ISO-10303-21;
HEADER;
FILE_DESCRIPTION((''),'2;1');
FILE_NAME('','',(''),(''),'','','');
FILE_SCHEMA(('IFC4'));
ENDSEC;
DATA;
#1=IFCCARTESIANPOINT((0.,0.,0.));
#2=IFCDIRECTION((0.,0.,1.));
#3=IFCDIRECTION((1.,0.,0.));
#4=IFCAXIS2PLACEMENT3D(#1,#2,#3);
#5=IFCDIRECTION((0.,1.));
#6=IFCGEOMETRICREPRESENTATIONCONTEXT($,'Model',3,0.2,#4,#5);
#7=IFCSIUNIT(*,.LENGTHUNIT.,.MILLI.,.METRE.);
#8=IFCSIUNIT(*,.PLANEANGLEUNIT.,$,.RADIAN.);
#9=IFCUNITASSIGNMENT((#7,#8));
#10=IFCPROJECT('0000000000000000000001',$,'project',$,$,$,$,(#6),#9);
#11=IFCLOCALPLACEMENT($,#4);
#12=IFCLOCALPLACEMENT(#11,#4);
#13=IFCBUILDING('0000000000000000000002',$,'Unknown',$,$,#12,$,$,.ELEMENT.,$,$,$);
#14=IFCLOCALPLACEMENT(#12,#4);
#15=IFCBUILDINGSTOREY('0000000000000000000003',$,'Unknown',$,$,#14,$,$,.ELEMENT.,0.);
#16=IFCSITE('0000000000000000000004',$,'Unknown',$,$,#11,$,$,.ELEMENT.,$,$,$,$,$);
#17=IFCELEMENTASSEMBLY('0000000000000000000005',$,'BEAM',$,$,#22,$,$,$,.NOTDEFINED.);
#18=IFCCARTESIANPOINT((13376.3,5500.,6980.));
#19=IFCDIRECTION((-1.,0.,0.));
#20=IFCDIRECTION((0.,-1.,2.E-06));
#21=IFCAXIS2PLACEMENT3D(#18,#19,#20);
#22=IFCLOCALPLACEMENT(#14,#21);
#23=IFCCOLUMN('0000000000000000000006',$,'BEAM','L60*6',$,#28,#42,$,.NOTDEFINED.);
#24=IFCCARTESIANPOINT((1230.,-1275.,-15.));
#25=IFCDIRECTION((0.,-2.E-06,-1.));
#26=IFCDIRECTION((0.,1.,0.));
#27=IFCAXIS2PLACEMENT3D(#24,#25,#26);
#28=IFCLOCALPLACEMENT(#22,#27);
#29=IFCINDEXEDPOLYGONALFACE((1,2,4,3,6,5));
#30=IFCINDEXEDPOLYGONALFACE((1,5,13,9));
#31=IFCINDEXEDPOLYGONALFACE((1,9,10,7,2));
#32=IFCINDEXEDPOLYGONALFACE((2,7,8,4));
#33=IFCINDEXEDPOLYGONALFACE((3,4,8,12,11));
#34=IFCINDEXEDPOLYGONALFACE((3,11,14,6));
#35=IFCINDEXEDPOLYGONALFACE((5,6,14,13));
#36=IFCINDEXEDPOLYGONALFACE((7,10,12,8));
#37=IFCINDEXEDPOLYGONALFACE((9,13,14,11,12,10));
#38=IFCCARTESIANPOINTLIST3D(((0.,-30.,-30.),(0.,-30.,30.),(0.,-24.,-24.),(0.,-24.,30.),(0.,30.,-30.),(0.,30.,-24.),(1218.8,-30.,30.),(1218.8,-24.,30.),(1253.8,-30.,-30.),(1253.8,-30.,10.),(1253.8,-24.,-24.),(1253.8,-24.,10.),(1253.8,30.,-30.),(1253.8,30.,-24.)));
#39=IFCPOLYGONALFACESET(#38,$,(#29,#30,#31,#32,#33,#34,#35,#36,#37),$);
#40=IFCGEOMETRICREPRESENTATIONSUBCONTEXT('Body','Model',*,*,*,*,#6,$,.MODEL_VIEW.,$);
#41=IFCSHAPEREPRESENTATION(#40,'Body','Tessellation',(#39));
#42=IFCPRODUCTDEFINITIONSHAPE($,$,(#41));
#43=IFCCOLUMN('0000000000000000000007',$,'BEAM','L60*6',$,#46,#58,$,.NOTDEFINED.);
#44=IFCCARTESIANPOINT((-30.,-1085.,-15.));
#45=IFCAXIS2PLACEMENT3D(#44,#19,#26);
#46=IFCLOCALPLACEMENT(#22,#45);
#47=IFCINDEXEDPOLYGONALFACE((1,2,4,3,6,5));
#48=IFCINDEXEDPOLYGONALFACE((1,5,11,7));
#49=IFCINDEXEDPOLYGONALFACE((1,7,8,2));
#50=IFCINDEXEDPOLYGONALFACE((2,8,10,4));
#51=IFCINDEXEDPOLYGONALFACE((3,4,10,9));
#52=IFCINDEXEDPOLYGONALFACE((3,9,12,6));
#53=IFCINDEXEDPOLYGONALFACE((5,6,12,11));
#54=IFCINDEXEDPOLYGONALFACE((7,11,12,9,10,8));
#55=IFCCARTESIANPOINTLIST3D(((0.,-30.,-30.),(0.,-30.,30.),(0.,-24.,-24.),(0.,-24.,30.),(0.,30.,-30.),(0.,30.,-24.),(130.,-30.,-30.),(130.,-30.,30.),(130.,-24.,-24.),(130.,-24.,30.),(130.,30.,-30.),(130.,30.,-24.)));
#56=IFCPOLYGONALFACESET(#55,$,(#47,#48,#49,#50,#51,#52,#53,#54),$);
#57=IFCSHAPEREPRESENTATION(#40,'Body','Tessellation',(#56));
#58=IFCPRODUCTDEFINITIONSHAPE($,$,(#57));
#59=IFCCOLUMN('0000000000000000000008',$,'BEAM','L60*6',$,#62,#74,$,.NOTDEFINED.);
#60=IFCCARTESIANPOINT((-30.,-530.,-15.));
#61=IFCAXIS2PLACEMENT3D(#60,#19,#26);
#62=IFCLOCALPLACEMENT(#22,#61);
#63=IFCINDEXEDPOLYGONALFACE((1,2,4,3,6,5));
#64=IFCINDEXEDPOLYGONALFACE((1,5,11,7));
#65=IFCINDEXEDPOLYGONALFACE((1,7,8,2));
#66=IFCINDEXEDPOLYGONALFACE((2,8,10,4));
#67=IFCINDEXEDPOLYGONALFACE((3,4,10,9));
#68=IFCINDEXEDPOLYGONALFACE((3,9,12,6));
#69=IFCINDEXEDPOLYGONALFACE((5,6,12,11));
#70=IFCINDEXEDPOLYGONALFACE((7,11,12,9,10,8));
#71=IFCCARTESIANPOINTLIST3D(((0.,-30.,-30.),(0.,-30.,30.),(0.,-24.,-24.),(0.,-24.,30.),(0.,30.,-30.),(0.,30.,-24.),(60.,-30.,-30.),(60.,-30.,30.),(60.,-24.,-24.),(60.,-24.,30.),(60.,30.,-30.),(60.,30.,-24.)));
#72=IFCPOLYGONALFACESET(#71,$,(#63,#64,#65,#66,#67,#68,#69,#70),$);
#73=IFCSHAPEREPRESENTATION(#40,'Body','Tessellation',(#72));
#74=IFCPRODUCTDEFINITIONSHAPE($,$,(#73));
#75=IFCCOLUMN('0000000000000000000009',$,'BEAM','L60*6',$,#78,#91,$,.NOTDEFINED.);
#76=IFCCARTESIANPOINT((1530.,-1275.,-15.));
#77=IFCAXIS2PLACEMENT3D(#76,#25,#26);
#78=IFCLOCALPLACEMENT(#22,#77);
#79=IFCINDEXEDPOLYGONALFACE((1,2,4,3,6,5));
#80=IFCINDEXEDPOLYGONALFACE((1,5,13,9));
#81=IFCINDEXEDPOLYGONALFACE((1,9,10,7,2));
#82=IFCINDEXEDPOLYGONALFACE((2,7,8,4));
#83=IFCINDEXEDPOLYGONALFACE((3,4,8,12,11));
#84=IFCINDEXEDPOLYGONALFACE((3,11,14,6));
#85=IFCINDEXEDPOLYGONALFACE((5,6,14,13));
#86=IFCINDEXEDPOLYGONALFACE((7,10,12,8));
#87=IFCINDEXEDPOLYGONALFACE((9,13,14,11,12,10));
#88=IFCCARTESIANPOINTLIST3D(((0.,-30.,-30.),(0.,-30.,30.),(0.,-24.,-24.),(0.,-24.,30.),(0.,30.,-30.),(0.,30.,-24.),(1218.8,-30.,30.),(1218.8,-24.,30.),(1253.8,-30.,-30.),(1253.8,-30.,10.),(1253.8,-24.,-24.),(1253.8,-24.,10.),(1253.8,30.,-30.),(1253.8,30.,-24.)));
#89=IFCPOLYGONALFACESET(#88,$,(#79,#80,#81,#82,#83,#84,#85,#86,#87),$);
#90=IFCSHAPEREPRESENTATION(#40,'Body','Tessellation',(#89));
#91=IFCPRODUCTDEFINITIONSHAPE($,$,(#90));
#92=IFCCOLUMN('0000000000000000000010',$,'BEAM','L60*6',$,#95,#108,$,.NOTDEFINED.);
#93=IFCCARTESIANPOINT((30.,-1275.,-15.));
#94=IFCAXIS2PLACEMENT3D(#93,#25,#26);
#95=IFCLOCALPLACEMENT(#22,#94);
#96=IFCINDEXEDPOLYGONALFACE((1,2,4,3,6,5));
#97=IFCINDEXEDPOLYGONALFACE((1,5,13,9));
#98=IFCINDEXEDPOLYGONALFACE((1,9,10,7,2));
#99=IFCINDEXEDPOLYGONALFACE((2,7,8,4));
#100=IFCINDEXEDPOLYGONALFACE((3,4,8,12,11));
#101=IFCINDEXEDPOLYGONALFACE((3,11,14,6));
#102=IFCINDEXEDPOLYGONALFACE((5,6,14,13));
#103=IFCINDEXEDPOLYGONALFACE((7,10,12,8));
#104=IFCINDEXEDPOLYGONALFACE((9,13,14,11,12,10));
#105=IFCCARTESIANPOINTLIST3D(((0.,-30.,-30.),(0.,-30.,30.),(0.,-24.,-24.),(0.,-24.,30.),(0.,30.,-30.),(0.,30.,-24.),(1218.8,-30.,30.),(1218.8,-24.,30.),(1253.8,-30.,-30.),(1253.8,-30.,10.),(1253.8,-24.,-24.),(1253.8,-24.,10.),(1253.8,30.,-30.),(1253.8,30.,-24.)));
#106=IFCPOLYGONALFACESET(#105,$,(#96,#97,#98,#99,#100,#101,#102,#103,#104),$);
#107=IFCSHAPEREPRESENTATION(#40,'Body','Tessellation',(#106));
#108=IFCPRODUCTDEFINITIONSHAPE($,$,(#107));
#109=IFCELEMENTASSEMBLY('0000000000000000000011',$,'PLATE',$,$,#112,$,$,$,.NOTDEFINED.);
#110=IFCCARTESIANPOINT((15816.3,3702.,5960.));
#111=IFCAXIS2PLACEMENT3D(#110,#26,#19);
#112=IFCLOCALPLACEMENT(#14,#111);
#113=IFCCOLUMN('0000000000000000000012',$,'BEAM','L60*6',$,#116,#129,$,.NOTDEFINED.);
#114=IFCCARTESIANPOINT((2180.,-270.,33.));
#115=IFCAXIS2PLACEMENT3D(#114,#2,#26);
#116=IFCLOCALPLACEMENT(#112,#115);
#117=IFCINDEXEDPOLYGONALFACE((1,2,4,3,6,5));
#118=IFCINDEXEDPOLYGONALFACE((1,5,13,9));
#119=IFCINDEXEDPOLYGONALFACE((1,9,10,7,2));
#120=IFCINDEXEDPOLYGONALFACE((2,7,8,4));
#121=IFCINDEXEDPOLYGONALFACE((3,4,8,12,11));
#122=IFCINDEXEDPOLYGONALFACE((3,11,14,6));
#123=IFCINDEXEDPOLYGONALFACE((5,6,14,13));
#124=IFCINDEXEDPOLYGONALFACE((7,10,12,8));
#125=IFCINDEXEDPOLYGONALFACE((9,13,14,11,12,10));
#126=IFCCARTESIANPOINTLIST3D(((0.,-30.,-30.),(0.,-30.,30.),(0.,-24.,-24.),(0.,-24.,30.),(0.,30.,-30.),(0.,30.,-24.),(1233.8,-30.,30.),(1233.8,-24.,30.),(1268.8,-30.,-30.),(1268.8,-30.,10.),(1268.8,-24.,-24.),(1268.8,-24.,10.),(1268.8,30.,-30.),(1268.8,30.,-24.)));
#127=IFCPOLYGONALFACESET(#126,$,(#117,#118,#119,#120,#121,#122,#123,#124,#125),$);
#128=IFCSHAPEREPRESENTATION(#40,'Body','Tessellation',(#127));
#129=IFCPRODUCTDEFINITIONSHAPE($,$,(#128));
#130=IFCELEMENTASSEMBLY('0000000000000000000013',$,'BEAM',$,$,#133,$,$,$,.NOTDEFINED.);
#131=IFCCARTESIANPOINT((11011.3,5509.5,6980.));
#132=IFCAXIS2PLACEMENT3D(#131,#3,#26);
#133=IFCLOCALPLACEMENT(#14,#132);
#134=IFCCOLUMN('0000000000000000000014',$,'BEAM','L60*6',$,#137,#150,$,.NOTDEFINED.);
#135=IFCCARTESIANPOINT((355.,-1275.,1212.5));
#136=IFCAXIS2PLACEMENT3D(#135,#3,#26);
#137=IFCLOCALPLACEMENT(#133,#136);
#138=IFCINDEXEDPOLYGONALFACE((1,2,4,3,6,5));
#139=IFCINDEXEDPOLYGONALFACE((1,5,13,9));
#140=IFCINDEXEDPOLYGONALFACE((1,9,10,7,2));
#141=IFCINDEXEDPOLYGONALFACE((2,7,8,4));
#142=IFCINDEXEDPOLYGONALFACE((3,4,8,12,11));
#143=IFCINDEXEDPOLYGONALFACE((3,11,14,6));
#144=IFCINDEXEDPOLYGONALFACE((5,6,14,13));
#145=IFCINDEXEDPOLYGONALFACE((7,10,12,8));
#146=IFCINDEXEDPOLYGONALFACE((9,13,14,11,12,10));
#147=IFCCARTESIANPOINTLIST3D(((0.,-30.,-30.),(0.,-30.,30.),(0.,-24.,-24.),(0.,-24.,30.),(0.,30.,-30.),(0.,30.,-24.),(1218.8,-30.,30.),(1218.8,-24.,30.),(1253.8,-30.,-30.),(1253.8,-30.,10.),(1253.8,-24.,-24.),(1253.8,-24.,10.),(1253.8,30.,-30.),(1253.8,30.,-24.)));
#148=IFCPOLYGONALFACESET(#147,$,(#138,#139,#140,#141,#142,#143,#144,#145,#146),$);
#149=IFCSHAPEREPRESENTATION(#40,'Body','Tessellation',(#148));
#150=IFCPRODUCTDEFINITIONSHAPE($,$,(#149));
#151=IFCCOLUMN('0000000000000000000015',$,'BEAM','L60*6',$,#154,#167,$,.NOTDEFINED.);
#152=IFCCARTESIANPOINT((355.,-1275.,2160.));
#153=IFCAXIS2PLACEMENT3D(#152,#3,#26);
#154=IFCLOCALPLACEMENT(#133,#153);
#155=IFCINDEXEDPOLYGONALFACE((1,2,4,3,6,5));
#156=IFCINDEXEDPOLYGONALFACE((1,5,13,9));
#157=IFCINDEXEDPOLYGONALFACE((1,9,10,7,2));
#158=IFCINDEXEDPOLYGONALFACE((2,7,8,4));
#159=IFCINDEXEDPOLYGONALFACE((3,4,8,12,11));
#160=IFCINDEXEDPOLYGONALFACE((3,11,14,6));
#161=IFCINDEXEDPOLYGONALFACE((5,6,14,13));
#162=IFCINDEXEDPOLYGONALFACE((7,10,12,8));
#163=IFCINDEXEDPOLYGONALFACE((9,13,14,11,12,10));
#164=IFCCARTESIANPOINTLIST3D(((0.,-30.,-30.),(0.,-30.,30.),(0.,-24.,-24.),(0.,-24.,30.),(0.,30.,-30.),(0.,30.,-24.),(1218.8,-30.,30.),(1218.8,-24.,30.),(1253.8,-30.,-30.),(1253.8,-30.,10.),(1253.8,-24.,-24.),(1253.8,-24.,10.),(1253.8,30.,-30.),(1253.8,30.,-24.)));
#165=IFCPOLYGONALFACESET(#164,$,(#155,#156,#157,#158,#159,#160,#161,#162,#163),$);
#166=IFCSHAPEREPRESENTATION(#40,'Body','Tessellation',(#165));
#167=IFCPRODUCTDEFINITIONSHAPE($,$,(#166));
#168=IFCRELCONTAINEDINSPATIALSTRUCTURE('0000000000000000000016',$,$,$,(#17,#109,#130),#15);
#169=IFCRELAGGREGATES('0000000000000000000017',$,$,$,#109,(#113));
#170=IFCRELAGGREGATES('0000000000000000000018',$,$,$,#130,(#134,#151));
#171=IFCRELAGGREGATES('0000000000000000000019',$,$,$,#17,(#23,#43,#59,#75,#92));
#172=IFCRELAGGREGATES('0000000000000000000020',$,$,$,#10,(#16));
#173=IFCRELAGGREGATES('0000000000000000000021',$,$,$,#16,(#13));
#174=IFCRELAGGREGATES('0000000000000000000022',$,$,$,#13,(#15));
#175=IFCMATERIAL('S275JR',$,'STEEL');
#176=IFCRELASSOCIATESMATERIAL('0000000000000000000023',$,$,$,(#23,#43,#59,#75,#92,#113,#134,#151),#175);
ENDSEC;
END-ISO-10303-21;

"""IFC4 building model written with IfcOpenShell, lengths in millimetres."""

from ifc_helpers import new_model, si_unit, direction, frame, origin_with_axes, place, context, subcontext, project, spatial, line, indexed_curve, outline, extrude, material, element, aggregate, save


model = new_model("IFC4")

# Units and contexts
model_context = context("Model", 3, precision=0.2, world=origin_with_axes(), true_north=direction((0.0, 1.0)))
body_context = subcontext(model_context, "Body", "Model", "MODEL_VIEW")
ifc_project = project(units=[si_unit("LENGTHUNIT", "METRE", prefix="MILLI"), si_unit("PLANEANGLEUNIT", "RADIAN")], contexts=[model_context])

# Site, building, storey
site_placement = place(None, origin_with_axes())
site = spatial("IfcSite", under=ifc_project, at=site_placement, Name="Unknown", CompositionType="ELEMENT")
building_placement = place(site_placement, origin_with_axes())
building = spatial("IfcBuilding", under=site, at=building_placement, Name="Unknown", CompositionType="ELEMENT")
storey_placement = place(building_placement, origin_with_axes())
storey = spatial("IfcBuildingStorey", under=building, at=storey_placement, Name="Unknown", CompositionType="ELEMENT", Elevation=0.0)

# Element assembly, columns, voiding features
assembly_1_placement = place(storey_placement, frame((13376.3, 5500.0, 6980.0), z_axis=(-1.0, 0.0, 0.0), x_axis=(0.0, -1.0, 0.000002)))
assembly_1 = element("IfcElementAssembly", 1, at=assembly_1_placement, inside=storey, Name="BEAM", PredefinedType="NOTDEFINED")
ifc_material_1 = material(Name="S275JR", Category="STEEL")
column_1_placement = place(assembly_1_placement, frame((1230.0, -1275.0, -15.0), z_axis=(0.0, -0.000002, -1.0), x_axis=(0.0, 1.0, 0.0)))
column_1 = element("IfcColumn", 2, at=column_1_placement, material=ifc_material_1, Name="BEAM", Description="L60*6", PredefinedType="NOTDEFINED", context=body_context, shape_type="SolidModel", body=[
    extrude(outline(indexed_curve([(-30.0, -30.0), (30.0, -30.0), (30.0, -24.0), (-24.0, -24.0), (-24.0, 30.0), (-30.0, 30.0)], segments=[line(1, 2, 3, 4, 5, 6, 1)])), frame((0.0, 0.0, 0.0), z_axis=(-1.0, 0.0, 0.0), x_axis=(0.0, 0.0, 1.0)), (0.0, -0.000002, -1.0), 1253.8),
])
voiding_feature_1_placement = place(column_1_placement, frame((1253.8, 0.0, 10.0), z_axis=(0.0, -1.0, 0.000002), x_axis=(0.0, 0.0, 1.0)))
element("IfcVoidingFeature", 3, at=voiding_feature_1_placement, cuts=column_1, Name="CUTPART", PredefinedType="HOLE", context=body_context, shape_type="SolidModel", body=[
    extrude(outline(indexed_curve([(0.0, 0.0), (20.0, 0.0), (20.0, 35.0)], segments=[line(1, 2, 3, 1)])), frame((0.0, 0.0, 33.0), z_axis=(0.0, 0.0, 1.0), x_axis=(1.0, 0.0, 0.0)), (0.0, -0.000002, -1.0), 66.0),
])
column_2_placement = place(assembly_1_placement, frame((-30.0, -1085.0, -15.0), z_axis=(-1.0, 0.0, 0.0), x_axis=(0.0, 1.0, 0.0)))
column_2 = element("IfcColumn", 4, at=column_2_placement, material=ifc_material_1, Name="BEAM", Description="L60*6", PredefinedType="NOTDEFINED", context=body_context, shape_type="SolidModel", body=[
    extrude(outline(indexed_curve([(-30.0, -30.0), (30.0, -30.0), (30.0, -24.0), (-24.0, -24.0), (-24.0, 30.0), (-30.0, 30.0)], segments=[line(1, 2, 3, 4, 5, 6, 1)])), frame((0.0, 0.0, 0.0), z_axis=(-1.0, 0.0, 0.0), x_axis=(0.0, 0.0, 1.0)), (0.0, -0.000002, -1.0), 130.0),
])
column_3_placement = place(assembly_1_placement, frame((-30.0, -530.0, -15.0), z_axis=(-1.0, 0.0, 0.0), x_axis=(0.0, 1.0, 0.0)))
column_3 = element("IfcColumn", 5, at=column_3_placement, material=ifc_material_1, Name="BEAM", Description="L60*6", PredefinedType="NOTDEFINED", context=body_context, shape_type="SolidModel", body=[
    extrude(outline(indexed_curve([(-30.0, -30.0), (30.0, -30.0), (30.0, -24.0), (-24.0, -24.0), (-24.0, 30.0), (-30.0, 30.0)], segments=[line(1, 2, 3, 4, 5, 6, 1)])), frame((0.0, 0.0, 0.0), z_axis=(-1.0, 0.0, 0.0), x_axis=(0.0, 0.0, 1.0)), (0.0, -0.000002, -1.0), 60.0),
])
column_4_placement = place(assembly_1_placement, frame((1530.0, -1275.0, -15.0), z_axis=(0.0, -0.000002, -1.0), x_axis=(0.0, 1.0, 0.0)))
column_4 = element("IfcColumn", 6, at=column_4_placement, material=ifc_material_1, Name="BEAM", Description="L60*6", PredefinedType="NOTDEFINED", context=body_context, shape_type="SolidModel", body=[
    extrude(outline(indexed_curve([(-30.0, -30.0), (30.0, -30.0), (30.0, -24.0), (-24.0, -24.0), (-24.0, 30.0), (-30.0, 30.0)], segments=[line(1, 2, 3, 4, 5, 6, 1)])), frame((0.0, 0.0, 0.0), z_axis=(-1.0, 0.0, 0.0), x_axis=(0.0, 0.0, 1.0)), (0.0, -0.000002, -1.0), 1253.8),
])
voiding_feature_2_placement = place(column_4_placement, frame((1253.8, 0.0, 10.0), z_axis=(0.0, -1.0, 0.000002), x_axis=(0.0, 0.0, 1.0)))
element("IfcVoidingFeature", 7, at=voiding_feature_2_placement, cuts=column_4, Name="CUTPART", PredefinedType="HOLE", context=body_context, shape_type="SolidModel", body=[
    extrude(outline(indexed_curve([(0.0, 0.0), (20.0, 0.0), (20.0, 35.0)], segments=[line(1, 2, 3, 1)])), frame((0.0, 0.0, 33.0), z_axis=(0.0, 0.0, 1.0), x_axis=(1.0, 0.0, 0.0)), (0.0, -0.000002, -1.0), 66.0),
])
column_5_placement = place(assembly_1_placement, frame((30.0, -1275.0, -15.0), z_axis=(0.0, -0.000002, -1.0), x_axis=(0.0, 1.0, 0.0)))
column_5 = element("IfcColumn", 8, at=column_5_placement, material=ifc_material_1, Name="BEAM", Description="L60*6", PredefinedType="NOTDEFINED", context=body_context, shape_type="SolidModel", body=[
    extrude(outline(indexed_curve([(-30.0, -30.0), (30.0, -30.0), (30.0, -24.0), (-24.0, -24.0), (-24.0, 30.0), (-30.0, 30.0)], segments=[line(1, 2, 3, 4, 5, 6, 1)])), frame((0.0, 0.0, 0.0), z_axis=(-1.0, 0.0, 0.0), x_axis=(0.0, 0.0, 1.0)), (0.0, -0.000002, -1.0), 1253.8),
])
voiding_feature_3_placement = place(column_5_placement, frame((1253.8, 0.0, 10.0), z_axis=(0.0, -1.0, 0.000002), x_axis=(0.0, 0.0, 1.0)))
element("IfcVoidingFeature", 9, at=voiding_feature_3_placement, cuts=column_5, Name="CUTPART", PredefinedType="HOLE", context=body_context, shape_type="SolidModel", body=[
    extrude(outline(indexed_curve([(0.0, 0.0), (20.0, 0.0), (20.0, 35.0)], segments=[line(1, 2, 3, 1)])), frame((0.0, 0.0, 33.0), z_axis=(0.0, 0.0, 1.0), x_axis=(1.0, 0.0, 0.0)), (0.0, -0.000002, -1.0), 66.0),
])

# Element assembly, column, voiding feature
assembly_2_placement = place(storey_placement, frame((15816.3, 3702.0, 5960.0), z_axis=(0.0, 1.0, 0.0), x_axis=(-1.0, 0.0, 0.0)))
assembly_2 = element("IfcElementAssembly", 10, at=assembly_2_placement, inside=storey, Name="PLATE", PredefinedType="NOTDEFINED")
column_6_placement = place(assembly_2_placement, frame((2180.0, -270.0, 33.0), z_axis=(0.0, 0.0, 1.0), x_axis=(0.0, 1.0, 0.0)))
column_6 = element("IfcColumn", 11, at=column_6_placement, material=ifc_material_1, Name="BEAM", Description="L60*6", PredefinedType="NOTDEFINED", context=body_context, shape_type="SolidModel", body=[
    extrude(outline(indexed_curve([(-30.0, -30.0), (30.0, -30.0), (30.0, -24.0), (-24.0, -24.0), (-24.0, 30.0), (-30.0, 30.0)], segments=[line(1, 2, 3, 4, 5, 6, 1)])), frame((0.0, 0.0, 0.0), z_axis=(-1.0, 0.0, 0.0), x_axis=(0.0, 0.0, 1.0)), (0.0, -0.000002, -1.0), 1268.8),
])
voiding_feature_4_placement = place(column_6_placement, frame((1268.8, 0.0, 10.0), z_axis=(0.0, -1.0, 0.000002), x_axis=(0.0, 0.0, 1.0)))
element("IfcVoidingFeature", 12, at=voiding_feature_4_placement, cuts=column_6, Name="CUTPART", PredefinedType="HOLE", context=body_context, shape_type="SolidModel", body=[
    extrude(outline(indexed_curve([(0.0, 0.0), (20.0, 0.0), (20.0, 35.0)], segments=[line(1, 2, 3, 1)])), frame((0.0, 0.0, 33.0), z_axis=(0.0, 0.0, 1.0), x_axis=(1.0, 0.0, 0.0)), (0.0, -0.000002, -1.0), 66.0),
])

# Element assembly, columns, voiding features
assembly_3_placement = place(storey_placement, frame((11011.3, 5509.5, 6980.0), z_axis=(1.0, 0.0, 0.0), x_axis=(0.0, 1.0, 0.0)))
assembly_3 = element("IfcElementAssembly", 13, at=assembly_3_placement, inside=storey, Name="BEAM", PredefinedType="NOTDEFINED")
column_7_placement = place(assembly_3_placement, frame((355.0, -1275.0, 1212.5), z_axis=(1.0, 0.0, 0.0), x_axis=(0.0, 1.0, 0.0)))
column_7 = element("IfcColumn", 14, at=column_7_placement, material=ifc_material_1, Name="BEAM", Description="L60*6", PredefinedType="NOTDEFINED", context=body_context, shape_type="SolidModel", body=[
    extrude(outline(indexed_curve([(-30.0, -30.0), (30.0, -30.0), (30.0, -24.0), (-24.0, -24.0), (-24.0, 30.0), (-30.0, 30.0)], segments=[line(1, 2, 3, 4, 5, 6, 1)])), frame((0.0, 0.0, 0.0), z_axis=(-1.0, 0.0, 0.0), x_axis=(0.0, 0.0, 1.0)), (0.0, -0.000002, -1.0), 1253.8),
])
voiding_feature_5_placement = place(column_7_placement, frame((1253.8, 0.0, 10.0), z_axis=(0.0, -1.0, 0.000002), x_axis=(0.0, 0.0, 1.0)))
element("IfcVoidingFeature", 15, at=voiding_feature_5_placement, cuts=column_7, Name="CUTPART", PredefinedType="HOLE", context=body_context, shape_type="SolidModel", body=[
    extrude(outline(indexed_curve([(0.0, 0.0), (20.0, 0.0), (20.0, 35.0)], segments=[line(1, 2, 3, 1)])), frame((0.0, 0.0, 33.0), z_axis=(0.0, 0.0, 1.0), x_axis=(1.0, 0.0, 0.0)), (0.0, -0.000002, -1.0), 66.0),
])
column_8_placement = place(assembly_3_placement, frame((355.0, -1275.0, 2160.0), z_axis=(1.0, 0.0, 0.0), x_axis=(0.0, 1.0, 0.0)))
column_8 = element("IfcColumn", 16, at=column_8_placement, material=ifc_material_1, Name="BEAM", Description="L60*6", PredefinedType="NOTDEFINED", context=body_context, shape_type="SolidModel", body=[
    extrude(outline(indexed_curve([(-30.0, -30.0), (30.0, -30.0), (30.0, -24.0), (-24.0, -24.0), (-24.0, 30.0), (-30.0, 30.0)], segments=[line(1, 2, 3, 4, 5, 6, 1)])), frame((0.0, 0.0, 0.0), z_axis=(-1.0, 0.0, 0.0), x_axis=(0.0, 0.0, 1.0)), (0.0, -0.000002, -1.0), 1253.8),
])
voiding_feature_6_placement = place(column_8_placement, frame((1253.8, 0.0, 10.0), z_axis=(0.0, -1.0, 0.000002), x_axis=(0.0, 0.0, 1.0)))
element("IfcVoidingFeature", 17, at=voiding_feature_6_placement, cuts=column_8, Name="CUTPART", PredefinedType="HOLE", context=body_context, shape_type="SolidModel", body=[
    extrude(outline(indexed_curve([(0.0, 0.0), (20.0, 0.0), (20.0, 35.0)], segments=[line(1, 2, 3, 1)])), frame((0.0, 0.0, 33.0), z_axis=(0.0, 0.0, 1.0), x_axis=(1.0, 0.0, 0.0)), (0.0, -0.000002, -1.0), 66.0),
])

aggregate(assembly_2, [column_6])
aggregate(assembly_3, [column_7, column_8])
aggregate(assembly_1, [column_1, column_2, column_3, column_4, column_5])

save(model, "model.ifc")
